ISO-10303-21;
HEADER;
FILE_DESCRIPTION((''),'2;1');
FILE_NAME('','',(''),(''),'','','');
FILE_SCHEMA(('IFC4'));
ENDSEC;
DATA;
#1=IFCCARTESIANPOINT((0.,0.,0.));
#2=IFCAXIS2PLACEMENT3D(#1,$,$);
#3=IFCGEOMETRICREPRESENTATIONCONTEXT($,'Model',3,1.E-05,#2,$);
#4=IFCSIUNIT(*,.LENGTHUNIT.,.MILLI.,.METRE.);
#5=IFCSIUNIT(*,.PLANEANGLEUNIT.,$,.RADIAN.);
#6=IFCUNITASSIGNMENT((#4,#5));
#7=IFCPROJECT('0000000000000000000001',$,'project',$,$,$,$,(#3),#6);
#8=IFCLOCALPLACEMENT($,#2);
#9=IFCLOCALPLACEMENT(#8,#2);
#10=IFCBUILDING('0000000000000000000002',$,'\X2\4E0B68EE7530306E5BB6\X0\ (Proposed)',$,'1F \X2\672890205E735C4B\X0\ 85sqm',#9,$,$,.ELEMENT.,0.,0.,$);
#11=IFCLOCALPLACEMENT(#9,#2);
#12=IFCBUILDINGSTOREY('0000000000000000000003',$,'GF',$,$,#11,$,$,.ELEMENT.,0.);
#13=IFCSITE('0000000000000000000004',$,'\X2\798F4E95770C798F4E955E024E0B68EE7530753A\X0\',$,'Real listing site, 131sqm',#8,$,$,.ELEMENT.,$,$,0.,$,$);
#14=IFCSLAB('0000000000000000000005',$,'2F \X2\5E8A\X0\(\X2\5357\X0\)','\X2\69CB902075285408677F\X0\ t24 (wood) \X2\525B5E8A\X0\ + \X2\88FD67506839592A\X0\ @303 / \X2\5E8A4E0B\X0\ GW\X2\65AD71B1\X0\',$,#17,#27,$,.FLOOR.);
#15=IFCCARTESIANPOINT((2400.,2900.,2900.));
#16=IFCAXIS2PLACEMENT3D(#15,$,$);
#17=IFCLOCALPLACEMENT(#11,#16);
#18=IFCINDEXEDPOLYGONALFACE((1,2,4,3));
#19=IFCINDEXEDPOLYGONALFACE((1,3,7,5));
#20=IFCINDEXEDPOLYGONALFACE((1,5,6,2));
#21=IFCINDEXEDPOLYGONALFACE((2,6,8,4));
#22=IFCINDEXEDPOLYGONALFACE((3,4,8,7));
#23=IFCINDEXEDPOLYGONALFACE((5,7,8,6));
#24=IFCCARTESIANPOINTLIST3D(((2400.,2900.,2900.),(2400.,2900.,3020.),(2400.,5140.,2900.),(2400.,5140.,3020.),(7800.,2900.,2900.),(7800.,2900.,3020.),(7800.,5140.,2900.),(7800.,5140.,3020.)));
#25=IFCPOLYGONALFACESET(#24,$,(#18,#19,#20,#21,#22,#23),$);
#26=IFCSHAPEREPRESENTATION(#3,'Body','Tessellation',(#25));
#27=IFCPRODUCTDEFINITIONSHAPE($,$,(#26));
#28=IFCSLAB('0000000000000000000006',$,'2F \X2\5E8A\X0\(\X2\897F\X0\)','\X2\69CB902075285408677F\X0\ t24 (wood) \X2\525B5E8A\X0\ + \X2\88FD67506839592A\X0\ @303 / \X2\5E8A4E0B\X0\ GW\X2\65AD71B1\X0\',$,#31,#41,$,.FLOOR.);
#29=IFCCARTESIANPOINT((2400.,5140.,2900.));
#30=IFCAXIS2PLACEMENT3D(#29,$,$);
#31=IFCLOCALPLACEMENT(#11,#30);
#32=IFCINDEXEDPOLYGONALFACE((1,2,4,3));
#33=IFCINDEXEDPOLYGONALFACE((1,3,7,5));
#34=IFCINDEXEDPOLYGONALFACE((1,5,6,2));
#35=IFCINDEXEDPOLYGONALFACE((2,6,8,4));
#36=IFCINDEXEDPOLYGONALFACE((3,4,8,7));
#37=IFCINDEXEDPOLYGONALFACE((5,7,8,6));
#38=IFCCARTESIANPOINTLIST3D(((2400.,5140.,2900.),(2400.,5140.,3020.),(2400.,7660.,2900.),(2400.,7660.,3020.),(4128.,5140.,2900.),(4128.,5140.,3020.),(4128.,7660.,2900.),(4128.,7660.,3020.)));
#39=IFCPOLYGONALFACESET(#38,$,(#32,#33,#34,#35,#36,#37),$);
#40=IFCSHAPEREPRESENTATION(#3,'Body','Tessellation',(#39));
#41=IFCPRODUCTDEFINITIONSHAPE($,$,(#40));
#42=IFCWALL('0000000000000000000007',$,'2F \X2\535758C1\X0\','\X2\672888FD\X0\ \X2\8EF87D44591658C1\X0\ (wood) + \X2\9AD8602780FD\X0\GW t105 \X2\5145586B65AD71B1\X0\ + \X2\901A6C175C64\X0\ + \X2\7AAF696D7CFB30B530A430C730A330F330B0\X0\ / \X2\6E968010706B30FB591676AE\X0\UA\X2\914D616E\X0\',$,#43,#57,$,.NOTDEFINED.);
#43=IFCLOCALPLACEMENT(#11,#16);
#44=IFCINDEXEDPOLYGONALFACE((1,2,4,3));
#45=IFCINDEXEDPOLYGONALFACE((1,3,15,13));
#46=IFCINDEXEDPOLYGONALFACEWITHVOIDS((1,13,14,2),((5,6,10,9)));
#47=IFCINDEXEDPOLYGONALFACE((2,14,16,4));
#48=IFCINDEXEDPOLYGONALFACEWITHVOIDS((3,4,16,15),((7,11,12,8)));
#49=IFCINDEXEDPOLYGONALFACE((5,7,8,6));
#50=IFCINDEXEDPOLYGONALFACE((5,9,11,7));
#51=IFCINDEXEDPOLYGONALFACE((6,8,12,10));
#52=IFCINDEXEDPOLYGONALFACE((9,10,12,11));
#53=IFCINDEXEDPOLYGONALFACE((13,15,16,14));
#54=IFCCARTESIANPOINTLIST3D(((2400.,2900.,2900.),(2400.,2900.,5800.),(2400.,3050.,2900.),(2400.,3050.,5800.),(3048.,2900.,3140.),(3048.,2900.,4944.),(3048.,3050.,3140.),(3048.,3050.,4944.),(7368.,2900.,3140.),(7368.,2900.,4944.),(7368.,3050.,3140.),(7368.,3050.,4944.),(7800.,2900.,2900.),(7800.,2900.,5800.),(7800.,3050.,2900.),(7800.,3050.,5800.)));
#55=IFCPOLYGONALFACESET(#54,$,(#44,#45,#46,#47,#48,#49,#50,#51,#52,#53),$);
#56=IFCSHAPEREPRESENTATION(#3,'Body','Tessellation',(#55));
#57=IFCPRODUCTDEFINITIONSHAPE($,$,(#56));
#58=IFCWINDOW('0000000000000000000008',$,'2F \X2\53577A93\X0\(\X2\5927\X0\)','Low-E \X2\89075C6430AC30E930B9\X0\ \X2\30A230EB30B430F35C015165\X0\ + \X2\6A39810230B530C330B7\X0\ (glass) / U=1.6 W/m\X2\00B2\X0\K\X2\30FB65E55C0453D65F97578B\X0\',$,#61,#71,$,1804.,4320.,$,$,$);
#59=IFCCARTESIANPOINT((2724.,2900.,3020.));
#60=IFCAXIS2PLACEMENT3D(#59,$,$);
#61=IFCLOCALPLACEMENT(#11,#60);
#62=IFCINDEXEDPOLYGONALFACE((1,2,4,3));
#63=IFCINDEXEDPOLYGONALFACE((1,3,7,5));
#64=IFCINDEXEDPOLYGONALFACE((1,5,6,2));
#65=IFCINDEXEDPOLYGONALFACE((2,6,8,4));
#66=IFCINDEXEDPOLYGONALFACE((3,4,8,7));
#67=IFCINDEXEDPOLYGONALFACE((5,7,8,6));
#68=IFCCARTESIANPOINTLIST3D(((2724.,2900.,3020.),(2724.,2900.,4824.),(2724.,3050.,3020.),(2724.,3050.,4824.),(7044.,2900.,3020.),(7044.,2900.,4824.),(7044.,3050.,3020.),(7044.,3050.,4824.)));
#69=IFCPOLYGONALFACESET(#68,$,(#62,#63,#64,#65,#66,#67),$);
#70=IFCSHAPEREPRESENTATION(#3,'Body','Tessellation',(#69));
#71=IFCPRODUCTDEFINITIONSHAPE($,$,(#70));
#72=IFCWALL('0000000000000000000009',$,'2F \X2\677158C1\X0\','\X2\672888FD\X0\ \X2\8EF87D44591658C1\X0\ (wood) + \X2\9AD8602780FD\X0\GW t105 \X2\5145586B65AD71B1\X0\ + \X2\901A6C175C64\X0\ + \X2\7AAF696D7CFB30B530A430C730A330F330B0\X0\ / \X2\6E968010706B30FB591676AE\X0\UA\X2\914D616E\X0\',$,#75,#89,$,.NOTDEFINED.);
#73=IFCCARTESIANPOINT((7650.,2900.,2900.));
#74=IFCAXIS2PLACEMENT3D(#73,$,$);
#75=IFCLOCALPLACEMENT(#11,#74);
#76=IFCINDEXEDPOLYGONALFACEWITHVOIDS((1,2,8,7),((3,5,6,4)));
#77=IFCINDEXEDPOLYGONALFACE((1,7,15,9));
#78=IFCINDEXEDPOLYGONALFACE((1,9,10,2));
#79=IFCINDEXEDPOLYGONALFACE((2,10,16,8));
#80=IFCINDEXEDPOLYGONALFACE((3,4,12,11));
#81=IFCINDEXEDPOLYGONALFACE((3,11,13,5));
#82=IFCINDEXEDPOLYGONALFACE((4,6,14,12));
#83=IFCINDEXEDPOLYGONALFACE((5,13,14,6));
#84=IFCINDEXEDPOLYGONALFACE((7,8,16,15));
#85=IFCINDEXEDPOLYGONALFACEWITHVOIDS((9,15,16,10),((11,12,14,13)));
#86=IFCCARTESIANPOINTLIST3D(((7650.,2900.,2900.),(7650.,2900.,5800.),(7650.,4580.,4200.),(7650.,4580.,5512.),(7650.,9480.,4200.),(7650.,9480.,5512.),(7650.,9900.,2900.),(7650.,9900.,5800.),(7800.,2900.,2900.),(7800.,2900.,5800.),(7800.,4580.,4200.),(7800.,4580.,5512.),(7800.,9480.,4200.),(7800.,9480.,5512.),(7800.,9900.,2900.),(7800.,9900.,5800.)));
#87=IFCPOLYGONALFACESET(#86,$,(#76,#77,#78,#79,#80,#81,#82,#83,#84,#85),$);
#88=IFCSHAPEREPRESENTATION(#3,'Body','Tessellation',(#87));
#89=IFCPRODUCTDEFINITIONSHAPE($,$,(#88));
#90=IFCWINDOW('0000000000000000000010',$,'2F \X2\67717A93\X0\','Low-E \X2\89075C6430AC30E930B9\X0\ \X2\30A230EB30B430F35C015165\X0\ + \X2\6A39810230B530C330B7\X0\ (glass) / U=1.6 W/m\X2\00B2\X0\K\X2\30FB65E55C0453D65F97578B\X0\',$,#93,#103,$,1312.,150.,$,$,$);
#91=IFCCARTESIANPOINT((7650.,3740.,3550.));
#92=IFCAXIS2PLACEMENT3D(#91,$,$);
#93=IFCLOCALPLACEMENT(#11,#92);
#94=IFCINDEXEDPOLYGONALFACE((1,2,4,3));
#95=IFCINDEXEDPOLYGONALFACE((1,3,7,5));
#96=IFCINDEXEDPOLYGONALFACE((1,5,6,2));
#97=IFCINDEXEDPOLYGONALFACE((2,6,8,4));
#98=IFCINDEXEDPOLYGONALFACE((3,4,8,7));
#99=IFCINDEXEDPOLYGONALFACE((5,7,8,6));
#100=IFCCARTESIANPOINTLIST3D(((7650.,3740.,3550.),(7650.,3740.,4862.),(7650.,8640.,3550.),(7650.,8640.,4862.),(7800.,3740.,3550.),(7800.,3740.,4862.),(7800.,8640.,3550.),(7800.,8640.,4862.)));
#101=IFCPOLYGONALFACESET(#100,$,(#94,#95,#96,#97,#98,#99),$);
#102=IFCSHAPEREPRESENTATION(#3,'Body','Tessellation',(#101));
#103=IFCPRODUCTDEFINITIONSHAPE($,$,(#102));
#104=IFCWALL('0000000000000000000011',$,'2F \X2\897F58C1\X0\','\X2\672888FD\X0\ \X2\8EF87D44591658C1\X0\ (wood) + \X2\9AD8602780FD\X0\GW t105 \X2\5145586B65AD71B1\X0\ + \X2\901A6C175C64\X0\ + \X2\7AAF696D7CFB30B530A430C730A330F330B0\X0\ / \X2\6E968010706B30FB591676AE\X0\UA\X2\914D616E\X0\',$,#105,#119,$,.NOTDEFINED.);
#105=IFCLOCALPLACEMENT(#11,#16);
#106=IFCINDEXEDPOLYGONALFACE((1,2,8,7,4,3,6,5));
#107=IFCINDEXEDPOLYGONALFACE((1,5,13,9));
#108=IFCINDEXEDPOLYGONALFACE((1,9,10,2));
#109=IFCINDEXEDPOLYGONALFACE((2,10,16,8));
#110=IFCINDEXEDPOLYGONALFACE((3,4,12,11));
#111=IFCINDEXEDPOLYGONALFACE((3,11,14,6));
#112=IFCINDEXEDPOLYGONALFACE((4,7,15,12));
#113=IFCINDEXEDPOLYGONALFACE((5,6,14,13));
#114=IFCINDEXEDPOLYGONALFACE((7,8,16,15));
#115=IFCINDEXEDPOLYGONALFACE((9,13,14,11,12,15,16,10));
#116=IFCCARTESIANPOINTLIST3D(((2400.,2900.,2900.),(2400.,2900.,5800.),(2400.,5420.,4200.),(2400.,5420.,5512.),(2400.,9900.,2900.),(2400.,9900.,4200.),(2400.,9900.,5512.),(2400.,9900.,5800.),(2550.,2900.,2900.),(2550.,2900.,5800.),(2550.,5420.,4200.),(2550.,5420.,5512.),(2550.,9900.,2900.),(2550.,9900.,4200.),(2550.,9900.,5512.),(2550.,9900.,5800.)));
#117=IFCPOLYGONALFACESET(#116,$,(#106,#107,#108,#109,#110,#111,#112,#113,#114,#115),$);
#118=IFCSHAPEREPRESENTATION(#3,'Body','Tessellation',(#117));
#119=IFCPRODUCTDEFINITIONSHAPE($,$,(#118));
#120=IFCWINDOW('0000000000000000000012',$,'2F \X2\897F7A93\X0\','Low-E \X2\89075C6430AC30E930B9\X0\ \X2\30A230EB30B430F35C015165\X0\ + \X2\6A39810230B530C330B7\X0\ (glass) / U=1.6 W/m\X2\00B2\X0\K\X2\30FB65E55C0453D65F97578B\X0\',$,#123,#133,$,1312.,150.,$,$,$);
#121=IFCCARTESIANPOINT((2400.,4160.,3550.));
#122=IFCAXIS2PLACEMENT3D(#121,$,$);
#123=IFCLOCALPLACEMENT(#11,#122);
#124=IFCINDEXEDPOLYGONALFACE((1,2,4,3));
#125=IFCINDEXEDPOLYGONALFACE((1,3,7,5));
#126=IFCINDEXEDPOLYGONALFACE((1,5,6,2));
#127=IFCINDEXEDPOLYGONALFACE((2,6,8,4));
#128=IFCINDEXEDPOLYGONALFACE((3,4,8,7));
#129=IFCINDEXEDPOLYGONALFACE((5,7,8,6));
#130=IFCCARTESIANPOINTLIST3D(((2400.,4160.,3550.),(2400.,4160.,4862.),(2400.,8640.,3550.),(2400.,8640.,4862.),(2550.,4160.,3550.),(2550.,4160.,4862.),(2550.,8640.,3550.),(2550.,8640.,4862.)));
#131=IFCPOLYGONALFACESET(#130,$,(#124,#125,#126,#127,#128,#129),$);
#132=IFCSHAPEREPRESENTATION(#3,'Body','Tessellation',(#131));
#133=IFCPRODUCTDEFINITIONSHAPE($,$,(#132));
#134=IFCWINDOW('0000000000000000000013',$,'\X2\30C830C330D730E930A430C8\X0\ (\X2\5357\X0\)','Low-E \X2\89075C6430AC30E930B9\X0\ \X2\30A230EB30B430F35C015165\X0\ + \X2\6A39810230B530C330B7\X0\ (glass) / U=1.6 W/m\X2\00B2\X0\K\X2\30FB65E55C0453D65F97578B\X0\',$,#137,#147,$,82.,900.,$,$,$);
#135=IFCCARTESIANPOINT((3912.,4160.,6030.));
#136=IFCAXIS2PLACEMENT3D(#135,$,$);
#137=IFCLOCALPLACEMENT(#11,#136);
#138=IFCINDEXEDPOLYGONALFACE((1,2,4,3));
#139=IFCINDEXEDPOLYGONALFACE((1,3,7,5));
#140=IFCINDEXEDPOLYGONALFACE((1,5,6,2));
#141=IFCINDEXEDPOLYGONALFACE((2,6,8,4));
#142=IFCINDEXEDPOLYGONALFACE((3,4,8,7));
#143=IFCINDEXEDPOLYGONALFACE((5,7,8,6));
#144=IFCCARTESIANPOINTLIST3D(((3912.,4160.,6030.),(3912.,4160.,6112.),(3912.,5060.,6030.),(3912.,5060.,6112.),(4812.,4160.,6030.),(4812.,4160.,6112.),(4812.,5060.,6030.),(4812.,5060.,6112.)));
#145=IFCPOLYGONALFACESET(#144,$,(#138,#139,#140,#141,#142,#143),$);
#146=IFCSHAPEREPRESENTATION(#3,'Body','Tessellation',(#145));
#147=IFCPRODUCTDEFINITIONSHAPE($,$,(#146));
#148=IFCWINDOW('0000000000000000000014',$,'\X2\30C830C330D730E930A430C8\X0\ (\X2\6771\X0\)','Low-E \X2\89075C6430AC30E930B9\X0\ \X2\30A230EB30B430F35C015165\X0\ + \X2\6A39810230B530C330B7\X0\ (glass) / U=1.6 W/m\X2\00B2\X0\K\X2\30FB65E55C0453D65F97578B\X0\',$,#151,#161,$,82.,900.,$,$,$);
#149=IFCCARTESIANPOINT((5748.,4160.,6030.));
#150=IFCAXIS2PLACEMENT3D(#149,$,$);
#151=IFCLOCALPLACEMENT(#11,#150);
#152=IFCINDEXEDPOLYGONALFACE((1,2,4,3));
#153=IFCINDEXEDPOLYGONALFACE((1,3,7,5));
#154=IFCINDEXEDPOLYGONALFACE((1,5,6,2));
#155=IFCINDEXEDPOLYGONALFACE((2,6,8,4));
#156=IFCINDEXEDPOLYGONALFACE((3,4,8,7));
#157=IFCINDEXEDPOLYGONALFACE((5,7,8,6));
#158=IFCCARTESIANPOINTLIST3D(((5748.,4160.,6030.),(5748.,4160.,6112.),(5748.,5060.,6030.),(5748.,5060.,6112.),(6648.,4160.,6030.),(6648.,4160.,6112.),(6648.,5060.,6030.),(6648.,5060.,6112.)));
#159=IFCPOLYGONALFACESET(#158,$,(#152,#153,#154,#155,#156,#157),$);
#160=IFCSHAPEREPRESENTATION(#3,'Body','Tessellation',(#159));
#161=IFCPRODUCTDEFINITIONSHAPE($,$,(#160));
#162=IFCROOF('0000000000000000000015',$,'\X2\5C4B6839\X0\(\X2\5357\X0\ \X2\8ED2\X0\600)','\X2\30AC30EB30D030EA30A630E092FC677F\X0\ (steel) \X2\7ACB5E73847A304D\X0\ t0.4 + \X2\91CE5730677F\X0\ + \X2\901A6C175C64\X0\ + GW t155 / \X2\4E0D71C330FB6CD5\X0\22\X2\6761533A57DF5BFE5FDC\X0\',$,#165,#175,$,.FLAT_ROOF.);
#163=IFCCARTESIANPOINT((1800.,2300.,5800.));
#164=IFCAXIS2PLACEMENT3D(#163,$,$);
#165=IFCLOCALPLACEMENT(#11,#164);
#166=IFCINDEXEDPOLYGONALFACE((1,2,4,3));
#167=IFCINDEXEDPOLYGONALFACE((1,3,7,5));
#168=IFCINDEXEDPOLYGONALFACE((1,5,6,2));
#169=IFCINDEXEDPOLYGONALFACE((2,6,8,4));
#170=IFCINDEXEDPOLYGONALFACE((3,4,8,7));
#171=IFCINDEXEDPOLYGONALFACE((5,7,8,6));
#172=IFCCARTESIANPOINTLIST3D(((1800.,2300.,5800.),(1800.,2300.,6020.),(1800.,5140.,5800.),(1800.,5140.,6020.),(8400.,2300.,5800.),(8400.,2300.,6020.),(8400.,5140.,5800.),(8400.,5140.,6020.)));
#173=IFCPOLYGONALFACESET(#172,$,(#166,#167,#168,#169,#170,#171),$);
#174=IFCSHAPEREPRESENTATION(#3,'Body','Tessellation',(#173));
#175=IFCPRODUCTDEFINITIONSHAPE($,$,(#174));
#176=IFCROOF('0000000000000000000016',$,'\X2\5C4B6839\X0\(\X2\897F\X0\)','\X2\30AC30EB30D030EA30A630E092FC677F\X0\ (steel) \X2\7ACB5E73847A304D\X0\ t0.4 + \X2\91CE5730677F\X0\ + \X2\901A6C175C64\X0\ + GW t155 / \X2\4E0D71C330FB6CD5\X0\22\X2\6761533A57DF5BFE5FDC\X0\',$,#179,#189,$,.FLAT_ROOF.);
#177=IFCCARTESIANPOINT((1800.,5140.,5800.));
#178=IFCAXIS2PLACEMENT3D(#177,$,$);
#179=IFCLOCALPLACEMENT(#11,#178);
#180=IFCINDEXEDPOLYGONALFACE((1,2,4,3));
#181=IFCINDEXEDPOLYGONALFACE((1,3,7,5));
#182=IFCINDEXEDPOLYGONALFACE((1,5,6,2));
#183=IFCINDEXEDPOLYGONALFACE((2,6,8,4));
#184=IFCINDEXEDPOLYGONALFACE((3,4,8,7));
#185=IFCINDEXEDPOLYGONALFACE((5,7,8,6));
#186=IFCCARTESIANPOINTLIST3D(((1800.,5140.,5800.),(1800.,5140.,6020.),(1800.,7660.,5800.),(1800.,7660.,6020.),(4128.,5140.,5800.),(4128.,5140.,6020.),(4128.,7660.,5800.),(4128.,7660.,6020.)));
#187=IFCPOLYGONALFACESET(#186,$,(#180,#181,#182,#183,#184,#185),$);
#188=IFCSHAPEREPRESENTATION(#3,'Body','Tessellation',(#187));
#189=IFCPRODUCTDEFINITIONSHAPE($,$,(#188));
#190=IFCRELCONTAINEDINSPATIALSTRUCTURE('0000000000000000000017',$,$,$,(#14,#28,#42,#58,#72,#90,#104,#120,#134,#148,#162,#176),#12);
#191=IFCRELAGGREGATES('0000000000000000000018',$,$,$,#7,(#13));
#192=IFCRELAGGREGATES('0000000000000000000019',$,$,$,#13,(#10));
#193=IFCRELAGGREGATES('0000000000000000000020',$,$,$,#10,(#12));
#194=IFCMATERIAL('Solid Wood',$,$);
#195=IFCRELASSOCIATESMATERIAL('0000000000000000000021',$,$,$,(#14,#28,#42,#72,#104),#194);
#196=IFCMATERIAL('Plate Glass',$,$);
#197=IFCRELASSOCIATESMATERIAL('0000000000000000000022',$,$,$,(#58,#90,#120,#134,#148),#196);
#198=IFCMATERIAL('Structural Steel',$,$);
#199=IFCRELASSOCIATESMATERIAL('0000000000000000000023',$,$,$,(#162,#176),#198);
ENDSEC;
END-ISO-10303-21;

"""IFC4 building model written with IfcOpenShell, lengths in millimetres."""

from ifc_helpers import new_model, si_unit, frame, frame_2d, origin, place, context, project, spatial, rectangle, extrude, material, element, fill, save


model = new_model("IFC4")

# Units and contexts
model_context = context("Model", 3, precision=1e-05, world=origin())
ifc_project = project(units=[si_unit("LENGTHUNIT", "METRE", prefix="MILLI"), si_unit("PLANEANGLEUNIT", "RADIAN")], contexts=[model_context])

# Site, building, storey
site_placement = place(None, origin())
site = spatial("IfcSite", under=ifc_project, at=site_placement, Name="福井県福井市下森田町", ObjectType="Real listing site, 131sqm", CompositionType="ELEMENT", RefElevation=0.0)
building_placement = place(site_placement, origin())
building = spatial("IfcBuilding", under=site, at=building_placement, Name="下森田の家 (Proposed)", ObjectType="1F 木造平屋 85sqm", CompositionType="ELEMENT", ElevationOfRefHeight=0.0, ElevationOfTerrain=0.0)
storey_placement = place(building_placement, origin())
storey = spatial("IfcBuildingStorey", under=building, at=storey_placement, Name="GF", CompositionType="ELEMENT", Elevation=0.0)

# Slabs
ifc_material_1 = material(Name="Solid Wood")
slab_1_placement = place(storey_placement, frame((2400.0, 2900.0, 2900.0)))
element("IfcSlab", 1, at=slab_1_placement, inside=storey, material=ifc_material_1, Name="2F 床(南)", Description="構造用合板 t24 (wood) 剛床 + 製材根太 @303 / 床下 GW断熱", PredefinedType="FLOOR", context=model_context, shape_type="SweptSolid", body=[
    extrude(rectangle(XDim=5400.0, YDim=2240.0, at=frame_2d((2700.0, 1120.0))), frame((2400.0, 2900.0, 2900.0)), (0.0, 0.0, 1.0), 120.0),
])
slab_2_placement = place(storey_placement, frame((2400.0, 5140.0, 2900.0)))
element("IfcSlab", 2, at=slab_2_placement, inside=storey, material=ifc_material_1, Name="2F 床(西)", Description="構造用合板 t24 (wood) 剛床 + 製材根太 @303 / 床下 GW断熱", PredefinedType="FLOOR", context=model_context, shape_type="SweptSolid", body=[
    extrude(rectangle(XDim=1728.0, YDim=2520.0, at=frame_2d((864.0, 1260.0))), frame((2400.0, 5140.0, 2900.0)), (0.0, 0.0, 1.0), 120.0),
])

# Walls, openings, windows
wall_1_placement = place(storey_placement, frame((2400.0, 2900.0, 2900.0)))
wall_1 = element("IfcWall", 3, at=wall_1_placement, inside=storey, material=ifc_material_1, Name="2F 南壁", Description="木製 軸組外壁 (wood) + 高性能GW t105 充填断熱 + 通気層 + 窯業系サイディング / 準耐火・外皮UA配慮", PredefinedType="NOTDEFINED", context=model_context, shape_type="SweptSolid", body=[
    extrude(rectangle(XDim=5400.0, YDim=150.0, at=frame_2d((2700.0, 75.0))), frame((2400.0, 2900.0, 2900.0)), (0.0, 0.0, 1.0), 2900.0),
])
opening_1_placement = place(storey_placement, frame((2724.0, 2900.0, 3020.0)))
opening_1 = element("IfcOpeningElement", 4, at=opening_1_placement, cuts=wall_1, PredefinedType="NOTDEFINED", context=model_context, shape_type="SweptSolid", body=[
    extrude(rectangle(XDim=4320.0, YDim=150.0, at=frame_2d((2160.0, 75.0))), frame((2724.0, 2900.0, 3020.0)), (0.0, 0.0, 1.0), 1804.0),
])
ifc_material_2 = material(Name="Plate Glass")
window_1_placement = place(storey_placement, frame((2724.0, 2900.0, 3020.0)))
window_1 = element("IfcWindow", 5, at=window_1_placement, inside=storey, material=ifc_material_2, Name="2F 南窓(大)", Description="Low-E 複層ガラス アルゴン封入 + 樹脂サッシ (glass) / U=1.6 W/m²K・日射取得型", OverallHeight=1804.0, OverallWidth=4320.0, context=model_context, shape_type="SweptSolid", body=[
    extrude(rectangle(XDim=4320.0, YDim=150.0, at=frame_2d((2160.0, 75.0))), frame((2724.0, 2900.0, 3020.0)), (0.0, 0.0, 1.0), 1804.0),
])
fill(opening_1, window_1)
wall_2_placement = place(storey_placement, frame((7650.0, 2900.0, 2900.0)))
wall_2 = element("IfcWall", 6, at=wall_2_placement, inside=storey, material=ifc_material_1, Name="2F 東壁", Description="木製 軸組外壁 (wood) + 高性能GW t105 充填断熱 + 通気層 + 窯業系サイディング / 準耐火・外皮UA配慮", PredefinedType="NOTDEFINED", context=model_context, shape_type="SweptSolid", body=[
    extrude(rectangle(XDim=150.0, YDim=7000.0, at=frame_2d((75.0, 3500.0))), frame((7650.0, 2900.0, 2900.0)), (0.0, 0.0, 1.0), 2900.0),
])
opening_2_placement = place(storey_placement, frame((7650.0, 3740.0, 3550.0)))
opening_2 = element("IfcOpeningElement", 7, at=opening_2_placement, cuts=wall_2, PredefinedType="NOTDEFINED", context=model_context, shape_type="SweptSolid", body=[
    extrude(rectangle(XDim=150.0, YDim=4900.0, at=frame_2d((75.0, 2450.0))), frame((7650.0, 3740.0, 3550.0)), (0.0, 0.0, 1.0), 1312.0),
])
window_2_placement = place(storey_placement, frame((7650.0, 3740.0, 3550.0)))
window_2 = element("IfcWindow", 8, at=window_2_placement, inside=storey, material=ifc_material_2, Name="2F 東窓", Description="Low-E 複層ガラス アルゴン封入 + 樹脂サッシ (glass) / U=1.6 W/m²K・日射取得型", OverallHeight=1312.0, OverallWidth=150.0, context=model_context, shape_type="SweptSolid", body=[
    extrude(rectangle(XDim=150.0, YDim=4900.0, at=frame_2d((75.0, 2450.0))), frame((7650.0, 3740.0, 3550.0)), (0.0, 0.0, 1.0), 1312.0),
])
fill(opening_2, window_2)
wall_3_placement = place(storey_placement, frame((2400.0, 2900.0, 2900.0)))
wall_3 = element("IfcWall", 9, at=wall_3_placement, inside=storey, material=ifc_material_1, Name="2F 西壁", Description="木製 軸組外壁 (wood) + 高性能GW t105 充填断熱 + 通気層 + 窯業系サイディング / 準耐火・外皮UA配慮", PredefinedType="NOTDEFINED", context=model_context, shape_type="SweptSolid", body=[
    extrude(rectangle(XDim=150.0, YDim=7000.0, at=frame_2d((75.0, 3500.0))), frame((2400.0, 2900.0, 2900.0)), (0.0, 0.0, 1.0), 2900.0),
])
opening_3_placement = place(storey_placement, frame((2400.0, 4160.0, 3550.0)))
opening_3 = element("IfcOpeningElement", 10, at=opening_3_placement, cuts=wall_3, PredefinedType="NOTDEFINED", context=model_context, shape_type="SweptSolid", body=[
    extrude(rectangle(XDim=150.0, YDim=4480.0, at=frame_2d((75.0, 2240.0))), frame((2400.0, 4160.0, 3550.0)), (0.0, 0.0, 1.0), 1312.0),
])
window_3_placement = place(storey_placement, frame((2400.0, 4160.0, 3550.0)))
window_3 = element("IfcWindow", 11, at=window_3_placement, inside=storey, material=ifc_material_2, Name="2F 西窓", Description="Low-E 複層ガラス アルゴン封入 + 樹脂サッシ (glass) / U=1.6 W/m²K・日射取得型", OverallHeight=1312.0, OverallWidth=150.0, context=model_context, shape_type="SweptSolid", body=[
    extrude(rectangle(XDim=150.0, YDim=4480.0, at=frame_2d((75.0, 2240.0))), frame((2400.0, 4160.0, 3550.0)), (0.0, 0.0, 1.0), 1312.0),
])
fill(opening_3, window_3)

# Windows
window_4_placement = place(storey_placement, frame((3912.0, 4160.0, 6030.0)))
element("IfcWindow", 12, at=window_4_placement, inside=storey, material=ifc_material_2, Name="トップライト (南)", Description="Low-E 複層ガラス アルゴン封入 + 樹脂サッシ (glass) / U=1.6 W/m²K・日射取得型", OverallHeight=82.0, OverallWidth=900.0, context=model_context, shape_type="SweptSolid", body=[
    extrude(rectangle(XDim=900.0, YDim=900.0, at=frame_2d((450.0, 450.0))), frame((3912.0, 4160.0, 6030.0)), (0.0, 0.0, 1.0), 82.0),
])
window_5_placement = place(storey_placement, frame((5748.0, 4160.0, 6030.0)))
element("IfcWindow", 13, at=window_5_placement, inside=storey, material=ifc_material_2, Name="トップライト (東)", Description="Low-E 複層ガラス アルゴン封入 + 樹脂サッシ (glass) / U=1.6 W/m²K・日射取得型", OverallHeight=82.0, OverallWidth=900.0, context=model_context, shape_type="SweptSolid", body=[
    extrude(rectangle(XDim=900.0, YDim=900.0, at=frame_2d((450.0, 450.0))), frame((5748.0, 4160.0, 6030.0)), (0.0, 0.0, 1.0), 82.0),
])

# Roofs
ifc_material_3 = material(Name="Structural Steel")
roof_1_placement = place(storey_placement, frame((1800.0, 2300.0, 5800.0)))
element("IfcRoof", 14, at=roof_1_placement, inside=storey, material=ifc_material_3, Name="屋根(南 軒600)", Description="ガルバリウム鋼板 (steel) 立平葺き t0.4 + 野地板 + 通気層 + GW t155 / 不燃・法22条区域対応", PredefinedType="FLAT_ROOF", context=model_context, shape_type="SweptSolid", body=[
    extrude(rectangle(XDim=6600.0, YDim=2840.0, at=frame_2d((3300.0, 1420.0))), frame((1800.0, 2300.0, 5800.0)), (0.0, 0.0, 1.0), 220.0),
])
roof_2_placement = place(storey_placement, frame((1800.0, 5140.0, 5800.0)))
element("IfcRoof", 15, at=roof_2_placement, inside=storey, material=ifc_material_3, Name="屋根(西)", Description="ガルバリウム鋼板 (steel) 立平葺き t0.4 + 野地板 + 通気層 + GW t155 / 不燃・法22条区域対応", PredefinedType="FLAT_ROOF", context=model_context, shape_type="SweptSolid", body=[
    extrude(rectangle(XDim=2328.0, YDim=2520.0, at=frame_2d((1164.0, 1260.0))), frame((1800.0, 5140.0, 5800.0)), (0.0, 0.0, 1.0), 220.0),
])

save(model, "model.ifc")
